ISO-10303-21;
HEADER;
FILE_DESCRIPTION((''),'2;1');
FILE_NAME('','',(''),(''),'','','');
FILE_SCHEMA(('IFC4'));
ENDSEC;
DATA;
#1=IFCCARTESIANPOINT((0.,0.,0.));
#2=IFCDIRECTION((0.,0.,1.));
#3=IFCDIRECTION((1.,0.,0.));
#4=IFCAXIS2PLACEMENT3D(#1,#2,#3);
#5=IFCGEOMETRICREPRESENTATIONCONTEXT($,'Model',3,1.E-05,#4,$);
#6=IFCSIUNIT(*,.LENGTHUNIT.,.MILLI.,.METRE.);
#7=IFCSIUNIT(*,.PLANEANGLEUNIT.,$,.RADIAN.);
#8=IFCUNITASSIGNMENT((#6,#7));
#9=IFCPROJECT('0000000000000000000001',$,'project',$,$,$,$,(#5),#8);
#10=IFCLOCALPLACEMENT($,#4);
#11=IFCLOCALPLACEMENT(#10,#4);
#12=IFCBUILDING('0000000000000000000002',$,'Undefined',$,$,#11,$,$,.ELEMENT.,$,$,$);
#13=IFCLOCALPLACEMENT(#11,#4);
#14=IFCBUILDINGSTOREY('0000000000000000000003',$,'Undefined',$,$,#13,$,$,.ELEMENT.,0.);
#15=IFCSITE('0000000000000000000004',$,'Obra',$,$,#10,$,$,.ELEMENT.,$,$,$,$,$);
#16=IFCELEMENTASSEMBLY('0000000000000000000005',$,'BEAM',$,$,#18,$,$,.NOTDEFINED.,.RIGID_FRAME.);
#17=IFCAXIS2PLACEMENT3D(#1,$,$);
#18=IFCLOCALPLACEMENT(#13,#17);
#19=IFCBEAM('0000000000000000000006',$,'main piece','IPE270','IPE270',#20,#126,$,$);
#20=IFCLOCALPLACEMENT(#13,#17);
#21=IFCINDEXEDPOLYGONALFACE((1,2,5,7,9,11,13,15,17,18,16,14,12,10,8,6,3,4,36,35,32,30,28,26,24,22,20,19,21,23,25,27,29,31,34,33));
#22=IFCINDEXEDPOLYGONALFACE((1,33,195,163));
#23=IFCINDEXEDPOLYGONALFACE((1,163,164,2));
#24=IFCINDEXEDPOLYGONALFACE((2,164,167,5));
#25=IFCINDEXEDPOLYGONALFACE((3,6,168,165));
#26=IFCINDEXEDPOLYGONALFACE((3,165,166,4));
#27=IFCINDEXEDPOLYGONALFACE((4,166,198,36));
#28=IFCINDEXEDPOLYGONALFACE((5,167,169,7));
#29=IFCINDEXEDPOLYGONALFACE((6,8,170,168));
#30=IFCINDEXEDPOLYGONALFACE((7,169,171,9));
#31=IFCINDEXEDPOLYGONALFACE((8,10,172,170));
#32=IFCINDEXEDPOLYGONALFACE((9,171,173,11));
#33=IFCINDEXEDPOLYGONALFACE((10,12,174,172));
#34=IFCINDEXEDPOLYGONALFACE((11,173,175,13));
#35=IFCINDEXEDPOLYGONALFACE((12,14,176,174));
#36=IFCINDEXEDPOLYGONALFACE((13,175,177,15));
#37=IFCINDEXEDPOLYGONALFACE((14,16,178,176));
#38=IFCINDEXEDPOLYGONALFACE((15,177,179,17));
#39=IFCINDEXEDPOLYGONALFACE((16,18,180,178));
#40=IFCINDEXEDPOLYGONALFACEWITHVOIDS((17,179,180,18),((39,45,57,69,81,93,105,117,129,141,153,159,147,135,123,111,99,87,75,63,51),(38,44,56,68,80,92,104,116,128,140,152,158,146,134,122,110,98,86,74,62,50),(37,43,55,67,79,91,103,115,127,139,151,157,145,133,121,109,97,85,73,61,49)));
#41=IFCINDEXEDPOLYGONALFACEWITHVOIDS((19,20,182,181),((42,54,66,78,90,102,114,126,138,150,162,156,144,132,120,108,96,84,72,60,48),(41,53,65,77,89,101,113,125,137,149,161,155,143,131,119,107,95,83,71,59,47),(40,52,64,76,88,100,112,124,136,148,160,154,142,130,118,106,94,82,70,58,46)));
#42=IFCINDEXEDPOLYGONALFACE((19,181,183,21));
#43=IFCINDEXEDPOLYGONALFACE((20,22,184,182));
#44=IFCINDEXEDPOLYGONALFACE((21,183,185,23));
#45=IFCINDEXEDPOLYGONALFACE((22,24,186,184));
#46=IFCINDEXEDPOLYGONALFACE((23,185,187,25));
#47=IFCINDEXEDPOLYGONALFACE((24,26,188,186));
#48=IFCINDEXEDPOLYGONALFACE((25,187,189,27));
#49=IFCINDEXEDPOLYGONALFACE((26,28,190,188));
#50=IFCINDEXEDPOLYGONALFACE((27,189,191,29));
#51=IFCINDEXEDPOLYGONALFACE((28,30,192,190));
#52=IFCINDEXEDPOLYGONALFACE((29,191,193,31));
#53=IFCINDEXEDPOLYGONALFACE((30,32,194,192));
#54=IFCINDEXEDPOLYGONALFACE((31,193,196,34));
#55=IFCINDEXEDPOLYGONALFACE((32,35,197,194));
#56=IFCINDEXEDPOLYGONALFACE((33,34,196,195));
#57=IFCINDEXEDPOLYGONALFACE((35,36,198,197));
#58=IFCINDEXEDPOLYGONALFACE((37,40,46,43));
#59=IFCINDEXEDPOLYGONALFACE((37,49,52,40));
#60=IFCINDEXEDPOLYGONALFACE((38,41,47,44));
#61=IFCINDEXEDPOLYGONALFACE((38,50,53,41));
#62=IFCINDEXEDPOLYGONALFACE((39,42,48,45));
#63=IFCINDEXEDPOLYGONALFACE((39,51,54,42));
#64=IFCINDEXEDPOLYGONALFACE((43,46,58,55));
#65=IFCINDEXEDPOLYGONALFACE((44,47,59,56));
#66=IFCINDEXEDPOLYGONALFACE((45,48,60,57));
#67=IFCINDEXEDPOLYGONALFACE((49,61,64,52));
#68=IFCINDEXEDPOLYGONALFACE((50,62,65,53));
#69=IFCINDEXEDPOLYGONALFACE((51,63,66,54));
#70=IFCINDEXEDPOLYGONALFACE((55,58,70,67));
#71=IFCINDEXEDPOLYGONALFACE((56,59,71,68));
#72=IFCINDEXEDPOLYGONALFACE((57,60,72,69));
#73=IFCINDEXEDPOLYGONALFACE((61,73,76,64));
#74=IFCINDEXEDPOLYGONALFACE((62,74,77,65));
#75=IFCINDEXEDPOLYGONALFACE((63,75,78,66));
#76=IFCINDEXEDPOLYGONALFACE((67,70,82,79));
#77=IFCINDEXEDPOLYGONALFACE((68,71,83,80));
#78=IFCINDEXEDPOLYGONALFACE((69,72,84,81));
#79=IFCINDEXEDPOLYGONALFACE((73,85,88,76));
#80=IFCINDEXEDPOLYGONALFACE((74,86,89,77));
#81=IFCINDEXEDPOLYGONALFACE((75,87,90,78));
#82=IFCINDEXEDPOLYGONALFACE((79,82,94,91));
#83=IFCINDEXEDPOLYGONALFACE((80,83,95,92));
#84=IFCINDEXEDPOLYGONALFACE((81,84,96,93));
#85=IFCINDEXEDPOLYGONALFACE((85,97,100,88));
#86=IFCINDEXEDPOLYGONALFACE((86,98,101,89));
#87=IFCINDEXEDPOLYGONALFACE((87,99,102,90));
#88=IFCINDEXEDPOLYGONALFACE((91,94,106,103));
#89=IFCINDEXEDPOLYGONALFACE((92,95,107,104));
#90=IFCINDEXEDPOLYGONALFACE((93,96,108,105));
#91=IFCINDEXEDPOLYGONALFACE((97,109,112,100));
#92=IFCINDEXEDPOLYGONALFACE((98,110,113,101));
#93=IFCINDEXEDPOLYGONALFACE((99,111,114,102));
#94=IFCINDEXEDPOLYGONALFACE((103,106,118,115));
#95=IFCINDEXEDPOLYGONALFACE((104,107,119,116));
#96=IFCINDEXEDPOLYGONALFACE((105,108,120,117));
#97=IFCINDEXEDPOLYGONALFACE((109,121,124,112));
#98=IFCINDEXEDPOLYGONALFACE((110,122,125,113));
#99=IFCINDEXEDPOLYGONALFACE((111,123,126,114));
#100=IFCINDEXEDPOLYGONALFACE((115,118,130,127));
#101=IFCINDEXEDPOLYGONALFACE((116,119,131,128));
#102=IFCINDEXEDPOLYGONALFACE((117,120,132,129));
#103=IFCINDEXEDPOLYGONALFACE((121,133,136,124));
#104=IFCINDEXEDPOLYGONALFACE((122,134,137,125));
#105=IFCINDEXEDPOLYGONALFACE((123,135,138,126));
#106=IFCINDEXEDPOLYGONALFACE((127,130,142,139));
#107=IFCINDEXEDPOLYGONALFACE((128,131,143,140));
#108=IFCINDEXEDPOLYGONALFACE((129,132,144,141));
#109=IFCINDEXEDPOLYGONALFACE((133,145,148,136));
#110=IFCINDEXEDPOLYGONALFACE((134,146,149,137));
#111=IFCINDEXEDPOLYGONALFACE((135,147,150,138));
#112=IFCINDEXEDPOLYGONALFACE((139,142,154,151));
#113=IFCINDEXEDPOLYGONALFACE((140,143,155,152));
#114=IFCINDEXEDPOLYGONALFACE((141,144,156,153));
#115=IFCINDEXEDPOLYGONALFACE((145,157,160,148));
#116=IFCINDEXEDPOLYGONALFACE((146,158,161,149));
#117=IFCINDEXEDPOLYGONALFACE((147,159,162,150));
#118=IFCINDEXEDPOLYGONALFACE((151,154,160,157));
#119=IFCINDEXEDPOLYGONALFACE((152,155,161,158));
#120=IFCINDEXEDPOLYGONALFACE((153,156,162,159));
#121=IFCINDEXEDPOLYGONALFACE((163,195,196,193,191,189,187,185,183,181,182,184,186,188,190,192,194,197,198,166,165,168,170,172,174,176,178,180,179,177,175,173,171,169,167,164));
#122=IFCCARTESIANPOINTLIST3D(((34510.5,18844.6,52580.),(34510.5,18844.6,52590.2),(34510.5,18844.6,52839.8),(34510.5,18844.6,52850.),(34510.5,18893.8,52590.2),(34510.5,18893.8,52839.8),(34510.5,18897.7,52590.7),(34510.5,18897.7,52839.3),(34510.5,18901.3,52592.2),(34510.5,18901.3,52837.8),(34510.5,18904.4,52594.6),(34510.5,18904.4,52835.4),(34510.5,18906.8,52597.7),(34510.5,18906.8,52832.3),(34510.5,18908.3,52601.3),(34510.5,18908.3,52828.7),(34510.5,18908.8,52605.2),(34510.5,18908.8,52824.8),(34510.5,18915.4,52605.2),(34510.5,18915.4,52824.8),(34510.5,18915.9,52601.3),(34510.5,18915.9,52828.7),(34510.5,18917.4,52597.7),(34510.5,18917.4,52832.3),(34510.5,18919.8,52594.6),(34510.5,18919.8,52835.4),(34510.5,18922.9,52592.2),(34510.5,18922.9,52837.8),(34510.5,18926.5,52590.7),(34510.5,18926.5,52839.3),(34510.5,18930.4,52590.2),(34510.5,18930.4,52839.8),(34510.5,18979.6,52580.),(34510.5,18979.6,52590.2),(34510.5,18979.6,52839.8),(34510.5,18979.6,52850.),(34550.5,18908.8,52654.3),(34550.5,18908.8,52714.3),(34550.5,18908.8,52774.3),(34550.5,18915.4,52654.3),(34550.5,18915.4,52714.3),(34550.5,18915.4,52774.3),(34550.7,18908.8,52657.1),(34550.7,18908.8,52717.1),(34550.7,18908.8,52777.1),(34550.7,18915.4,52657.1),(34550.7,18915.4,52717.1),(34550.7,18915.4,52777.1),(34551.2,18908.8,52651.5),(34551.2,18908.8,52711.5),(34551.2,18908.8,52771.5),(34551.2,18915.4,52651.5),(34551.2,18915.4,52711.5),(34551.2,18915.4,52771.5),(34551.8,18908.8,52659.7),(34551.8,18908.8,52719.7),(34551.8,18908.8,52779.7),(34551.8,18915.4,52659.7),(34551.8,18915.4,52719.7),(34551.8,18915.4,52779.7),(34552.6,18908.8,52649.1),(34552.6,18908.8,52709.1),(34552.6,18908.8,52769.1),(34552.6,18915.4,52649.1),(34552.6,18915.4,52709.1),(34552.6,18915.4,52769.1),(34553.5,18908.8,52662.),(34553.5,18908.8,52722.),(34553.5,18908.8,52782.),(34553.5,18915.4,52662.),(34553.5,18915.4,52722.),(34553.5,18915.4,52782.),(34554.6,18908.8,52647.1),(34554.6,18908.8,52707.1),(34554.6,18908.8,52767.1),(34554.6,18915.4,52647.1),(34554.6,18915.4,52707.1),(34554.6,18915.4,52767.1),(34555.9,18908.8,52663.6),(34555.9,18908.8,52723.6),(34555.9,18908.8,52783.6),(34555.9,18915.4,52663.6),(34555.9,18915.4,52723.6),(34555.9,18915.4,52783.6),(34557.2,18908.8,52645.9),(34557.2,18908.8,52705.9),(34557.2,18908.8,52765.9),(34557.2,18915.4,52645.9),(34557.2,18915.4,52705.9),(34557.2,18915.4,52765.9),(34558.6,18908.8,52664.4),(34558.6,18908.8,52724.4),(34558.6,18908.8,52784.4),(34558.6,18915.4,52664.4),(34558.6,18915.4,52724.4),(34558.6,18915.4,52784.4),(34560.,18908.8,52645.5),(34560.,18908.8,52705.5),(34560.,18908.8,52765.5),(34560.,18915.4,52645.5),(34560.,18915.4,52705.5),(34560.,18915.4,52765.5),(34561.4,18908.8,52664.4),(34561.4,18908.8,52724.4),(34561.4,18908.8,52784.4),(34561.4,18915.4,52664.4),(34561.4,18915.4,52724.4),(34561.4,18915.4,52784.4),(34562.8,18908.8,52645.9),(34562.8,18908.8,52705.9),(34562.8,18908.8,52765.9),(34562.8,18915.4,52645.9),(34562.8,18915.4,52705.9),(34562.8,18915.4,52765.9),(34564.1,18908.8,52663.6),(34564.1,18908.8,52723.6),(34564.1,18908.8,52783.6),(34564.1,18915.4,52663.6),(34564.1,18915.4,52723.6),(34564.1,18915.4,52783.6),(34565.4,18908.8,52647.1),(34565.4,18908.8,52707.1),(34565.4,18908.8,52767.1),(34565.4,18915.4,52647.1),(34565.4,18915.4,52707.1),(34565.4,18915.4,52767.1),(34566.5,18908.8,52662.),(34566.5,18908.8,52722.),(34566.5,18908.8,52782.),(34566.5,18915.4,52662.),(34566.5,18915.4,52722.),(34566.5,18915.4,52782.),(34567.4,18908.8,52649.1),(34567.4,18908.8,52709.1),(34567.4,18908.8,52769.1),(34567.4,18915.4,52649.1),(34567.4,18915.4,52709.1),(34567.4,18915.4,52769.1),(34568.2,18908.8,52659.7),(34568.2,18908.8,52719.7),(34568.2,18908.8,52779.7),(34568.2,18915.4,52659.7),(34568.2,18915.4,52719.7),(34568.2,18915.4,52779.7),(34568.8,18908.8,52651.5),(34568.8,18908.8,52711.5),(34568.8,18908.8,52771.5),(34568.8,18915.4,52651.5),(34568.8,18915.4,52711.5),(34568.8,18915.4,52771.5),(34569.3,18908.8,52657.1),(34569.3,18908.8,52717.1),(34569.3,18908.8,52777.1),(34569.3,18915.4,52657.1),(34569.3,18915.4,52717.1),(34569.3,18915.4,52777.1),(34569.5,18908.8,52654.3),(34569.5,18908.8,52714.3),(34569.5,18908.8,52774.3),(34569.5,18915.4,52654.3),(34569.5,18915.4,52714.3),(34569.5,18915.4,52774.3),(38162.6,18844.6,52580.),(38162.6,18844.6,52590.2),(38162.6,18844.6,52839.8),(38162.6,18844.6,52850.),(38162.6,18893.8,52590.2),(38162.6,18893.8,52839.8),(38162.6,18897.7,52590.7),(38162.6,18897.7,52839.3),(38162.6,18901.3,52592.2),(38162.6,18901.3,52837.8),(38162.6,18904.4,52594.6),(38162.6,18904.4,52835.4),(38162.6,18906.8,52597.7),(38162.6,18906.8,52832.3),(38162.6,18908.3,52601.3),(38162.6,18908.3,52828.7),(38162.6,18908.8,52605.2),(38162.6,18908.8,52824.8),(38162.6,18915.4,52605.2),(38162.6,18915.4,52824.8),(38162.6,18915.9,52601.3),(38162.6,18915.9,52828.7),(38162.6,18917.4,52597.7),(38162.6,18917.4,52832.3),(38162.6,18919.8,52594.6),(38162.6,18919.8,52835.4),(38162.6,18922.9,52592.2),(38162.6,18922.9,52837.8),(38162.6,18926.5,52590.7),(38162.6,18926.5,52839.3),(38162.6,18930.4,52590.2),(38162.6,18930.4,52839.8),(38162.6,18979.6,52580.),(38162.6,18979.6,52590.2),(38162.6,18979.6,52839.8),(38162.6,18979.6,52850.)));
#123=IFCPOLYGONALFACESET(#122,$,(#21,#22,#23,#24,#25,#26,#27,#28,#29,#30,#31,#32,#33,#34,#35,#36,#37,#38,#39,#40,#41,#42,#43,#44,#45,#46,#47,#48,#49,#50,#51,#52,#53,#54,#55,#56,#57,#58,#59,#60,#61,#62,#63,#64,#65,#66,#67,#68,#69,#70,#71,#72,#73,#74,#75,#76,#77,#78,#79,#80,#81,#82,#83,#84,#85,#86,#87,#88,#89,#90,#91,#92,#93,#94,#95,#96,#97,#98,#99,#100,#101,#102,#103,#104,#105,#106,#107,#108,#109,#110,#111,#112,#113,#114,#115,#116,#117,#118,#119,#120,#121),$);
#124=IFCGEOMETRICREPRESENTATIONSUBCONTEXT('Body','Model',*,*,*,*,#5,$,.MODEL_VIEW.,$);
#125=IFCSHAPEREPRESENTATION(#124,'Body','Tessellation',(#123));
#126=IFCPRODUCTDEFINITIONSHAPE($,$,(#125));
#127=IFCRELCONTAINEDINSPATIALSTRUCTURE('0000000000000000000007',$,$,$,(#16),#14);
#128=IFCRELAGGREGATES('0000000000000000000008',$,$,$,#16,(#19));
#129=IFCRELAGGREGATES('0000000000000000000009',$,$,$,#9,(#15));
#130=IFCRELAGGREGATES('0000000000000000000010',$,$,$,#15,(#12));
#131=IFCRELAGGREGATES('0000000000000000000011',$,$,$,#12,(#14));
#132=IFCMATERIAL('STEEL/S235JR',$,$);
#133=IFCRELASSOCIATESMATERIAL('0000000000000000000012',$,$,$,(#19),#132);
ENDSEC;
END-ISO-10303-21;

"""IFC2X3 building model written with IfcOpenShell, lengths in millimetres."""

from ifc_helpers import new_model, si_unit, frame, origin_with_axes, origin_2d_with_axis, place, context, subcontext, project, spatial, circle, i_section, extrude, clip, halfspace, source, transform, mapped, material, element, aggregate, save


model = new_model("IFC2X3")

# Units and contexts
model_context = context("Model", 3, precision=1e-05, world=origin_with_axes())
body_context = subcontext(model_context, "Body", "Model", "MODEL_VIEW")
ifc_project = project(units=[si_unit("LENGTHUNIT", "METRE", prefix="MILLI"), si_unit("PLANEANGLEUNIT", "RADIAN")], contexts=[model_context])

# Site, building, storey
site_placement = place(None, origin_with_axes())
site = spatial("IfcSite", under=ifc_project, at=site_placement, Name="Obra", CompositionType="ELEMENT")
building_placement = place(site_placement, origin_with_axes())
building = spatial("IfcBuilding", under=site, at=building_placement, Name="Undefined", CompositionType="ELEMENT")
storey_placement = place(building_placement, origin_with_axes())
storey = spatial("IfcBuildingStorey", under=building, at=storey_placement, Name="Undefined", CompositionType="ELEMENT", Elevation=0.0)

# Shared definitions
ifc_material_1 = material(Name="STEEL/S235JR")

# Element assembly, beam, opening
shared_shape_1 = source(origin_with_axes(), body_context, "Body", "SweptSolid", [
    extrude(circle(Radius=9.5, at=origin_2d_with_axis()), frame((0.0, -3.4, 0.0), z_axis=(0.0, 1.0, 0.0), x_axis=(1.0, 0.0, 0.0)), (0.0, 0.0, 1.0), 6.8),
])
assembly_1_placement = place(storey_placement, origin_with_axes())
assembly_1 = element("IfcElementAssembly", 1, at=assembly_1_placement, inside=storey, Name="BEAM", AssemblyPlace="NOTDEFINED", PredefinedType="RIGID_FRAME")
beam_1_placement = place(assembly_1_placement, frame((34251.7, 18912.1, 52715.0), z_axis=(0.0, 0.0, 1.0), x_axis=(1.0, 0.0, 0.0)))
beam_1 = element("IfcBeam", 2, at=beam_1_placement, material=ifc_material_1, Name="main piece", Description="IPE270", ObjectType="IPE270", context=body_context, shape_type="Clipping", body=[
    clip(extrude(i_section(OverallWidth=135.0, OverallDepth=270.0, WebThickness=6.6, FlangeThickness=10.2, FilletRadius=15.0, at=origin_2d_with_axis()), frame((3910.9, 0.0, 0.0), z_axis=(-1.0, 0.0, 0.0), x_axis=(0.0, -1.0, 0.0)), (0.0, 0.0, 1.0), 3910.9), halfspace(frame((258.8, 60.0, -120.0), z_axis=(-1.0, -0.000019, 0.0), x_axis=(0.0, 0.0, 1.0)), False)),
])
opening_1_placement = place(assembly_1_placement, frame((34510.0, 18912.1, 52835.0), z_axis=(1.0, 0.0, 0.0), x_axis=(0.0, 0.0, -1.0)))
element("IfcOpeningElement", 3, at=opening_1_placement, cuts=beam_1, ObjectType="Opening", context=body_context, shape_type="MappedRepresentation", body=[
    mapped(shared_shape_1, transform((60.0, 0.0, 50.0))),
    mapped(shared_shape_1, transform((120.0, 0.0, 50.0))),
    mapped(shared_shape_1, transform((180.0, 0.0, 50.0))),
])
aggregate(assembly_1, [beam_1])

save(model, "model.ifc")
